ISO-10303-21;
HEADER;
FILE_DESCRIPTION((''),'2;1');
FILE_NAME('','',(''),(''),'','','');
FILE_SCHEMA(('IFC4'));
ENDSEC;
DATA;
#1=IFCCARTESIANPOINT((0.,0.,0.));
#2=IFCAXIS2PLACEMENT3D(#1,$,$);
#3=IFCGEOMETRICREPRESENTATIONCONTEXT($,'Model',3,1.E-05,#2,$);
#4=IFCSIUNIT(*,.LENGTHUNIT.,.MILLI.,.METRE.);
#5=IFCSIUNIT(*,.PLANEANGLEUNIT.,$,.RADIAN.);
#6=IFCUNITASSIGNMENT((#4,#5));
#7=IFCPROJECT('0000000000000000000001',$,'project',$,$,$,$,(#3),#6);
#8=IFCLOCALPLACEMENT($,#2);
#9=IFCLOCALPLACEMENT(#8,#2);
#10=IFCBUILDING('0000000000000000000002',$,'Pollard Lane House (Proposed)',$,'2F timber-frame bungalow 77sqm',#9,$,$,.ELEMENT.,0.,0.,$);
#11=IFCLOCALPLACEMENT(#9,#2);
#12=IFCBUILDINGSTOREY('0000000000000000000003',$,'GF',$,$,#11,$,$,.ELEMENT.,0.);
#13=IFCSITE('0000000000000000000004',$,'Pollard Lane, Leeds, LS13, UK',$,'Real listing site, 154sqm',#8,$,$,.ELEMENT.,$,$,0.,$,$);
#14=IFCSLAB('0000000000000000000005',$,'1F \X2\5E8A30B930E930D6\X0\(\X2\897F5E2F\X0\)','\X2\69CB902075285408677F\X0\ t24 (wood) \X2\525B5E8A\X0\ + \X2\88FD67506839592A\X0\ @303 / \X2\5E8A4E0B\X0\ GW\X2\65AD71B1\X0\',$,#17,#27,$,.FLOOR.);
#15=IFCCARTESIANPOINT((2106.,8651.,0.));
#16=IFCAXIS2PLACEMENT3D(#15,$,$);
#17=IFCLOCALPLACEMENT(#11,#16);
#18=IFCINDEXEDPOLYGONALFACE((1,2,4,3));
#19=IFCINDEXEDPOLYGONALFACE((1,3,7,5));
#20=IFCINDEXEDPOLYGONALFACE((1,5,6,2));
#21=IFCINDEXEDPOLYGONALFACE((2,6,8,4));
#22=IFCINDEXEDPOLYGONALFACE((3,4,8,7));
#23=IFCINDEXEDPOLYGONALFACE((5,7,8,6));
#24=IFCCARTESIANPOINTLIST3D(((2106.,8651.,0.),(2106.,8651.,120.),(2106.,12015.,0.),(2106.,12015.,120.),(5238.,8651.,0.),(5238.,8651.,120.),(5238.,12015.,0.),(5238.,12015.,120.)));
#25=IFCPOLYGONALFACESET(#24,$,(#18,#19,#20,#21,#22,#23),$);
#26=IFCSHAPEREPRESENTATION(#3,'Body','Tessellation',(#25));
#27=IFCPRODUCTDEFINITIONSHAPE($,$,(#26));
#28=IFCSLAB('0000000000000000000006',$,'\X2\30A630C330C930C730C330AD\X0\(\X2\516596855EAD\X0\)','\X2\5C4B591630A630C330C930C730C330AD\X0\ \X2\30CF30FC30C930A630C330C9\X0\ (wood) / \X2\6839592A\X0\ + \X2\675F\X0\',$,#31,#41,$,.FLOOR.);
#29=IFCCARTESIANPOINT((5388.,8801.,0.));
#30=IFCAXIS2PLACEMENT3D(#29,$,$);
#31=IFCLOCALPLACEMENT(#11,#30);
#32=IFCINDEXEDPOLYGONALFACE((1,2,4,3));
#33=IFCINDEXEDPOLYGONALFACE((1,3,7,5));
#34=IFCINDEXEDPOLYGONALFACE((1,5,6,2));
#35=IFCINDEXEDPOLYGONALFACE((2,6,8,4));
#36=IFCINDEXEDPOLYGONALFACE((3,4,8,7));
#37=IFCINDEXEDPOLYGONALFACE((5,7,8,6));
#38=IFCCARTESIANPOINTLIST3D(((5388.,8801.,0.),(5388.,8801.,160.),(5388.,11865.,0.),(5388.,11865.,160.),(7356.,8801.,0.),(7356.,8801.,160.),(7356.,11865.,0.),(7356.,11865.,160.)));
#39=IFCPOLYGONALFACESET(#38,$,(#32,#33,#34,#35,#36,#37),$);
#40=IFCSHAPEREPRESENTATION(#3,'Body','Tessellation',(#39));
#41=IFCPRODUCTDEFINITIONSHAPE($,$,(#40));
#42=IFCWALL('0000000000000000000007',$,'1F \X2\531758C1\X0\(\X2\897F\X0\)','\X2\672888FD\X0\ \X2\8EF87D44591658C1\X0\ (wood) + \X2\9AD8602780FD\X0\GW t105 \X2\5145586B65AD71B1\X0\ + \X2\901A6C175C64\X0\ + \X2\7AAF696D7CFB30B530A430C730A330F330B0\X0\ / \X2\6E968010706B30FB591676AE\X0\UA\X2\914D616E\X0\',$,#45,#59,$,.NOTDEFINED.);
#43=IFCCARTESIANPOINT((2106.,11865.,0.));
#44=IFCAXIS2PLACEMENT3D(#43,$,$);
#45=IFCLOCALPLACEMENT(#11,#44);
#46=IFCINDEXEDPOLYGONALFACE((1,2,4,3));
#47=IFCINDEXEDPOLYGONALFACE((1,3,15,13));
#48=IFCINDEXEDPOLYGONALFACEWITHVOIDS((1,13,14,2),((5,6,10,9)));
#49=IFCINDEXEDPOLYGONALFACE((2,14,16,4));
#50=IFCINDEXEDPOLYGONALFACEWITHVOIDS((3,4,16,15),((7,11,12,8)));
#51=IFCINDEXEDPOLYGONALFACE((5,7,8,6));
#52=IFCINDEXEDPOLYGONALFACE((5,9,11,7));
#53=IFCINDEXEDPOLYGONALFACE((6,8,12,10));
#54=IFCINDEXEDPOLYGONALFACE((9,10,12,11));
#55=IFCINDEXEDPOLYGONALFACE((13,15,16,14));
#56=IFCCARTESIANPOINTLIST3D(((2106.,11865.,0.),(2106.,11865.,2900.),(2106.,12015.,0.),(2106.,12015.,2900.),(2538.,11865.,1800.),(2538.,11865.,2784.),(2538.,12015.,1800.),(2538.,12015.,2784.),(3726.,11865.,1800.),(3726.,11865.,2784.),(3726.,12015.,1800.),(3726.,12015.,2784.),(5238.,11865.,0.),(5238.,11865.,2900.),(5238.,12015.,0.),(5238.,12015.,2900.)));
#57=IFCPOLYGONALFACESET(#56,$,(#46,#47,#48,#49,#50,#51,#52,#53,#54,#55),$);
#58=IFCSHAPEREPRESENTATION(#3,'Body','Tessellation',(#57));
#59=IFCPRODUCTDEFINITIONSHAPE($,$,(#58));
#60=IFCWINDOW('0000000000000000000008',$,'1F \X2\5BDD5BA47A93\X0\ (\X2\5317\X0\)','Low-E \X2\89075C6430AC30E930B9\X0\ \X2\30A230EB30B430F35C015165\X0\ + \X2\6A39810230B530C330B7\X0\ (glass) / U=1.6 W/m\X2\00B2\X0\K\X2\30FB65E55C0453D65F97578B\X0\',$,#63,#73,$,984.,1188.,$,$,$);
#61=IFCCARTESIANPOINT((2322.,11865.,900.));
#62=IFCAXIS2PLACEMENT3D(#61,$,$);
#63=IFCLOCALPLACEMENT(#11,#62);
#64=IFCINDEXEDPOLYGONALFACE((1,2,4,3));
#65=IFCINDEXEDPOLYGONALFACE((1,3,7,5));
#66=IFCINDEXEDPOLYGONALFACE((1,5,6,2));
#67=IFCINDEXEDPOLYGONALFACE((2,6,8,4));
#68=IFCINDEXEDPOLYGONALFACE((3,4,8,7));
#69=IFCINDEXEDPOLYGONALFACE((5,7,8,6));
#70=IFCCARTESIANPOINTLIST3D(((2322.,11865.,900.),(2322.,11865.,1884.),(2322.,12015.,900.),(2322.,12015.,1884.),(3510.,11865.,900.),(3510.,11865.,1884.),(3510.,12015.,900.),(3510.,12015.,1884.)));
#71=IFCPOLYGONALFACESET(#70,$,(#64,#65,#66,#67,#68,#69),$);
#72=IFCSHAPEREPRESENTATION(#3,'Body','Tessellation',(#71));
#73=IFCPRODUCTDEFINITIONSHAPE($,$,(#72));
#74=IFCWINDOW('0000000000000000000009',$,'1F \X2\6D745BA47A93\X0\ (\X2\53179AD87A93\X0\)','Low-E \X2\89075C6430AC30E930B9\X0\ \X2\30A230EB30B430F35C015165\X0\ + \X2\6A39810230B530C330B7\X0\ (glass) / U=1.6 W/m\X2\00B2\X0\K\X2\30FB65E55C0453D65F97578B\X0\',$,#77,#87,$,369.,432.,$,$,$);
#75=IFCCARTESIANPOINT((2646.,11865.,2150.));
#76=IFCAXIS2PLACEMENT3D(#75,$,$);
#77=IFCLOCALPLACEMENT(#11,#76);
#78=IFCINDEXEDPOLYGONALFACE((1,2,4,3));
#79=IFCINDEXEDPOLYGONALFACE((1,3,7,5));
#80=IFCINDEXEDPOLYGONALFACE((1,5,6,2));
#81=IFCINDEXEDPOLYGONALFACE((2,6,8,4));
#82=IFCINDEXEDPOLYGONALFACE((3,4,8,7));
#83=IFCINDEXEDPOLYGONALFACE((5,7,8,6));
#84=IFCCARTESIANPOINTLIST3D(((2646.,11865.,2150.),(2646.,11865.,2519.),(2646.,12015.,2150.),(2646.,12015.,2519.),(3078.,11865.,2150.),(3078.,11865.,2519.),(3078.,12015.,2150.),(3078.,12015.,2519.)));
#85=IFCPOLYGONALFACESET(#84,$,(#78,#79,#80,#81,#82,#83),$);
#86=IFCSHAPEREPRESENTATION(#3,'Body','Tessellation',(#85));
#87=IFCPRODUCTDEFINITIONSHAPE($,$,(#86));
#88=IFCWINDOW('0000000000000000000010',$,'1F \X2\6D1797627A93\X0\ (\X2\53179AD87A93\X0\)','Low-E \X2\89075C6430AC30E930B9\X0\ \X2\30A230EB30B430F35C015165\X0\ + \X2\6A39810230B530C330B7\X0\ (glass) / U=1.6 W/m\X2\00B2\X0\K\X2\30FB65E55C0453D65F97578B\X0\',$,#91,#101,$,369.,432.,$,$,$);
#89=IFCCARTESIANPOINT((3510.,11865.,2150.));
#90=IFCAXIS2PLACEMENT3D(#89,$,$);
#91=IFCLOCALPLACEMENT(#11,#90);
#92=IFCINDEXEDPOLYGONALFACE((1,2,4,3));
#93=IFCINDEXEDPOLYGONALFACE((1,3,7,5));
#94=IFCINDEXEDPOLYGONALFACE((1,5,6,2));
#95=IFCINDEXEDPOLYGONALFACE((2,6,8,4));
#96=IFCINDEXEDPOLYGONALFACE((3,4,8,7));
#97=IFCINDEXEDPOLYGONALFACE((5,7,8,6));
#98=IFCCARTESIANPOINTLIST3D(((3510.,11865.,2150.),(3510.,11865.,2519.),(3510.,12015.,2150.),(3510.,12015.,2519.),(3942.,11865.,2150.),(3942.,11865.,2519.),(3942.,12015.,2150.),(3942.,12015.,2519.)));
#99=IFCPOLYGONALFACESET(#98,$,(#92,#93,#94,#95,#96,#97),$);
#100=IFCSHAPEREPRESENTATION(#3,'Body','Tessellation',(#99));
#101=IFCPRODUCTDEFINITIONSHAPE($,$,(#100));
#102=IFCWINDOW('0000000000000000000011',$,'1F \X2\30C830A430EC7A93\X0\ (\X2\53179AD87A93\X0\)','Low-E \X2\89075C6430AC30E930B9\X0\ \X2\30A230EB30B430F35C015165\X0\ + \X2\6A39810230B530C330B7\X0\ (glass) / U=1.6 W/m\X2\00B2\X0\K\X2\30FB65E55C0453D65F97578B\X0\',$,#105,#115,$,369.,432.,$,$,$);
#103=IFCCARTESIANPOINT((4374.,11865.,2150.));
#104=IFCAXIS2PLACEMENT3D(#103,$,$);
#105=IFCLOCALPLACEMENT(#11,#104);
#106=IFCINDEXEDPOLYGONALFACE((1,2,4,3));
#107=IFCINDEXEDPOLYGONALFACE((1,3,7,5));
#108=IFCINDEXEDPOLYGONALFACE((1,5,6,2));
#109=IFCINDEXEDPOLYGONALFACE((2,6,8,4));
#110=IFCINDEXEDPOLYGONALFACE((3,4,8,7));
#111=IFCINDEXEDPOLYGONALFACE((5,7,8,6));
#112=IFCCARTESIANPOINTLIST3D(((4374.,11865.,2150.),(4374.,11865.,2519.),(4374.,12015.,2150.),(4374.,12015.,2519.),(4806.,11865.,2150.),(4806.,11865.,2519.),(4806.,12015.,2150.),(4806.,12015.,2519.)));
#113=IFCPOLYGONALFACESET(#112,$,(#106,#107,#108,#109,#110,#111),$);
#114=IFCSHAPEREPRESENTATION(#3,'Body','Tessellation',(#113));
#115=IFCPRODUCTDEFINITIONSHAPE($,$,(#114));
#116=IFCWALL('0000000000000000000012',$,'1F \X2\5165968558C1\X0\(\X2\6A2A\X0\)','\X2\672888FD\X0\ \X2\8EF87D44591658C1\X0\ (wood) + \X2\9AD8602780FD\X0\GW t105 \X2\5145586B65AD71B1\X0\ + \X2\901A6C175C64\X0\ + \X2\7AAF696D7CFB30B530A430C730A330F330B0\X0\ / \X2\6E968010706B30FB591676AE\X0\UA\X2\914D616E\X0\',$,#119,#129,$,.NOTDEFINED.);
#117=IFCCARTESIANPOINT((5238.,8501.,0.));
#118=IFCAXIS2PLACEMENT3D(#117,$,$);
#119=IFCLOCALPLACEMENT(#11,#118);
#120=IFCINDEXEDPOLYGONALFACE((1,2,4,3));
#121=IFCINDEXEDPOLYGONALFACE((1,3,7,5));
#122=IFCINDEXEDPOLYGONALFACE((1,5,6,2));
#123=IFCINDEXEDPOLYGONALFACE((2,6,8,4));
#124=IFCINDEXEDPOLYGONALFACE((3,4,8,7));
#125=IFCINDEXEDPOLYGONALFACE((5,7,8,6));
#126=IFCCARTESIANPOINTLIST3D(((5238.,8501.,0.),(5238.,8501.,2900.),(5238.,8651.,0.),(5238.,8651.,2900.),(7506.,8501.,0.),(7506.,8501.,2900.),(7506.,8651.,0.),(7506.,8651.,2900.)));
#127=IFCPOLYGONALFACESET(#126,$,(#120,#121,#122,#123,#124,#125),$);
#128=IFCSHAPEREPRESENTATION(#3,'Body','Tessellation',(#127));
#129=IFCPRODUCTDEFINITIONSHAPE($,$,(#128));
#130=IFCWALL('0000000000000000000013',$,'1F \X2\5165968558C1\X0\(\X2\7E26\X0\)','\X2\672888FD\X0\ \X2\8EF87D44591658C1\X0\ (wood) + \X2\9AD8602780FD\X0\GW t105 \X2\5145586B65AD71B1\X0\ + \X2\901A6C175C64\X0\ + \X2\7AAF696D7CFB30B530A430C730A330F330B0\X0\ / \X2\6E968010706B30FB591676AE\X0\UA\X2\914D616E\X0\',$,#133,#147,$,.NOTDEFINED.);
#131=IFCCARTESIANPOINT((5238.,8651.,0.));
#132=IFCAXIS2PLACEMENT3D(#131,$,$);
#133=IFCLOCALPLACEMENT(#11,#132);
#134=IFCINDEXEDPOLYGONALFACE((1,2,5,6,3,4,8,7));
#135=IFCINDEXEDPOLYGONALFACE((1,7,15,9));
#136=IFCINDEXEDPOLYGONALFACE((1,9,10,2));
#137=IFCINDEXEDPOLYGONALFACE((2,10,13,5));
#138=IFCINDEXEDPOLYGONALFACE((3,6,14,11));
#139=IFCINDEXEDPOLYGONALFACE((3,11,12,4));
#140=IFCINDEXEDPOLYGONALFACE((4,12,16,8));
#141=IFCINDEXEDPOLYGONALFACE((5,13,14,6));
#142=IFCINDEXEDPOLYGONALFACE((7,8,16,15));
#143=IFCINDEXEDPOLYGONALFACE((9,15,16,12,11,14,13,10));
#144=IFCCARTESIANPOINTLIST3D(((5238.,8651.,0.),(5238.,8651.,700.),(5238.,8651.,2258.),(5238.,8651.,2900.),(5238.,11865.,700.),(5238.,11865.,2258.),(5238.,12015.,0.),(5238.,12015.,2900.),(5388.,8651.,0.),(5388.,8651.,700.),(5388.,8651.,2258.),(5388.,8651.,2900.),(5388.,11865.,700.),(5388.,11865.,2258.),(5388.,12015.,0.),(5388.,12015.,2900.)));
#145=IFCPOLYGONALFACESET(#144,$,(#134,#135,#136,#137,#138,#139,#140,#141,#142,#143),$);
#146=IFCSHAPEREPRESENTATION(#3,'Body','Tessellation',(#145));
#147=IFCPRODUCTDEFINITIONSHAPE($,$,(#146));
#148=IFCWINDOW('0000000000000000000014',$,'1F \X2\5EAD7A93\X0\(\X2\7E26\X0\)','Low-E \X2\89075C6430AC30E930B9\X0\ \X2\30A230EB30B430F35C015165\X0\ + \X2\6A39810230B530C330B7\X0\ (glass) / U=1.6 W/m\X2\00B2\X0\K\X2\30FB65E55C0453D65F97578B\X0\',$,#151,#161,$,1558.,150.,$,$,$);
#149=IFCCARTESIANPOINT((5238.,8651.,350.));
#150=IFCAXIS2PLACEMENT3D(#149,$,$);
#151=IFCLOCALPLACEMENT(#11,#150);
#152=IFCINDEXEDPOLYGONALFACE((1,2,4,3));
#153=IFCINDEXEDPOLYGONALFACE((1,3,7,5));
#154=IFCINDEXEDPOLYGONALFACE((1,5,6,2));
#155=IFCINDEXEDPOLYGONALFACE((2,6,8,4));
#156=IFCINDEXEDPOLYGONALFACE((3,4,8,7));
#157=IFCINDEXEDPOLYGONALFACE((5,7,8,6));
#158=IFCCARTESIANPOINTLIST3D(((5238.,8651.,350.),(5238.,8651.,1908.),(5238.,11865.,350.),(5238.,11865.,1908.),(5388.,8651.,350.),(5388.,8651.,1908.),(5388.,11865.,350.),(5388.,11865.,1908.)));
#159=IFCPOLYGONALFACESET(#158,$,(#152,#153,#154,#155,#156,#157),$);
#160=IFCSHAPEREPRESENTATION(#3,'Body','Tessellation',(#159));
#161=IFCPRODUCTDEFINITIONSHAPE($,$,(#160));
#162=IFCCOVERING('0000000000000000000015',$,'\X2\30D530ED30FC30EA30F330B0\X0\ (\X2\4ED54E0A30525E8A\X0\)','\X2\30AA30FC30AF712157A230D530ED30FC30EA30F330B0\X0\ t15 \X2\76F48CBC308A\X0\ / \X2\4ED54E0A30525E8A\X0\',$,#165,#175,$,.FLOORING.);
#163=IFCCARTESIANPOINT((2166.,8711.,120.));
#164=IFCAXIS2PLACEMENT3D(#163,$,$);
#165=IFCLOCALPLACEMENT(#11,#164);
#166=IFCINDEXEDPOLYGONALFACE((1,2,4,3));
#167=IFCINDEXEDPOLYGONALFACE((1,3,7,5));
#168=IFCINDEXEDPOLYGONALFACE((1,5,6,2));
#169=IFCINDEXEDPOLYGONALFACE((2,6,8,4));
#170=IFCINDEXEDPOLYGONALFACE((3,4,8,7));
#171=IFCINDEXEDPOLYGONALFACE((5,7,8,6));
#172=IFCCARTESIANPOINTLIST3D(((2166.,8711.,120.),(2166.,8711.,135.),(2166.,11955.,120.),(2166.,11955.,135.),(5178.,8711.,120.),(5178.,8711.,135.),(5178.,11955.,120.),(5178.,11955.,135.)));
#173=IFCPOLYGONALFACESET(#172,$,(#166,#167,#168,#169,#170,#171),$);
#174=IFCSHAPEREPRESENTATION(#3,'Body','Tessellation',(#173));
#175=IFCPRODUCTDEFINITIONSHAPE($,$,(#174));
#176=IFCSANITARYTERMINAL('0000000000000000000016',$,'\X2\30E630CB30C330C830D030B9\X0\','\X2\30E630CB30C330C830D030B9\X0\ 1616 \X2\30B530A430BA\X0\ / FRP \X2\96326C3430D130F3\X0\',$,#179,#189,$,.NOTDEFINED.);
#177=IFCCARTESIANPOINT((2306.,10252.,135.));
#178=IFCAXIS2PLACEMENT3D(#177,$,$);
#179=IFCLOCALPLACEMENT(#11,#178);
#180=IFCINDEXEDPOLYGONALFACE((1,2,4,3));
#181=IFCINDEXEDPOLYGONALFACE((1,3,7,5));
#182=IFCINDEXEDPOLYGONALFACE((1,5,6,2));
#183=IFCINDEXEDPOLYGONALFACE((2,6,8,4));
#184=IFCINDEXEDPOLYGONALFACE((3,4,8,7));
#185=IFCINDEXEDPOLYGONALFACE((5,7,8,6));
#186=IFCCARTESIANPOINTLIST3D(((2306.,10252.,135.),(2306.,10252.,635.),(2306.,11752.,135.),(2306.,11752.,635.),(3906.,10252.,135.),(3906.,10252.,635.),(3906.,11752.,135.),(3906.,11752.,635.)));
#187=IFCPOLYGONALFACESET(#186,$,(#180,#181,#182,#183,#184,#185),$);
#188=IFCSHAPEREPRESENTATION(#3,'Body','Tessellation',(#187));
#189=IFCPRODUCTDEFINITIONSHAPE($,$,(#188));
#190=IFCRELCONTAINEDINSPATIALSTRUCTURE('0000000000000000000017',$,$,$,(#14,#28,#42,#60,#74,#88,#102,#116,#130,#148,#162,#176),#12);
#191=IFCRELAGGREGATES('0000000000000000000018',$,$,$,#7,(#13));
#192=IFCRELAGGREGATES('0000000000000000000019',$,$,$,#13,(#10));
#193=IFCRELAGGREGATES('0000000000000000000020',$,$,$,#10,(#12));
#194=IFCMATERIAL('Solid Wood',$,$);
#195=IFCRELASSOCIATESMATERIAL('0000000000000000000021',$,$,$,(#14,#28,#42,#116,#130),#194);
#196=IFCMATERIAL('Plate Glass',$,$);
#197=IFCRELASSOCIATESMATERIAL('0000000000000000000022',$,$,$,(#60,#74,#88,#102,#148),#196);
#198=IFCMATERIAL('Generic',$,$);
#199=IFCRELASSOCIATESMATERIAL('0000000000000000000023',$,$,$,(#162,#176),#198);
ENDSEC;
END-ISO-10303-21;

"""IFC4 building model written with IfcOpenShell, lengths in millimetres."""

from ifc_helpers import new_model, si_unit, frame, frame_2d, origin, place, context, project, spatial, rectangle, extrude, material, element, fill, save


model = new_model("IFC4")

# Units and contexts
model_context = context("Model", 3, precision=1e-05, world=origin())
ifc_project = project(units=[si_unit("LENGTHUNIT", "METRE", prefix="MILLI"), si_unit("PLANEANGLEUNIT", "RADIAN")], contexts=[model_context])

# Site, building, storey
site_placement = place(None, origin())
site = spatial("IfcSite", under=ifc_project, at=site_placement, Name="Pollard Lane, Leeds, LS13, UK", ObjectType="Real listing site, 154sqm", CompositionType="ELEMENT", RefElevation=0.0)
building_placement = place(site_placement, origin())
building = spatial("IfcBuilding", under=site, at=building_placement, Name="Pollard Lane House (Proposed)", ObjectType="2F timber-frame bungalow 77sqm", CompositionType="ELEMENT", ElevationOfRefHeight=0.0, ElevationOfTerrain=0.0)
storey_placement = place(building_placement, origin())
storey = spatial("IfcBuildingStorey", under=building, at=storey_placement, Name="GF", CompositionType="ELEMENT", Elevation=0.0)

# Slabs
ifc_material_1 = material(Name="Solid Wood")
slab_1_placement = place(storey_placement, frame((2106.0, 8651.0, 0.0)))
element("IfcSlab", 1, at=slab_1_placement, inside=storey, material=ifc_material_1, Name="1F 床スラブ(西帯)", Description="構造用合板 t24 (wood) 剛床 + 製材根太 @303 / 床下 GW断熱", PredefinedType="FLOOR", context=model_context, shape_type="SweptSolid", body=[
    extrude(rectangle(XDim=3132.0, YDim=3364.0, at=frame_2d((1566.0, 1682.0))), frame((2106.0, 8651.0, 0.0)), (0.0, 0.0, 1.0), 120.0),
])
slab_2_placement = place(storey_placement, frame((5388.0, 8801.0, 0.0)))
element("IfcSlab", 2, at=slab_2_placement, inside=storey, material=ifc_material_1, Name="ウッドデッキ(入隅庭)", Description="屋外ウッドデッキ ハードウッド (wood) / 根太 + 束", PredefinedType="FLOOR", context=model_context, shape_type="SweptSolid", body=[
    extrude(rectangle(XDim=1968.0, YDim=3064.0, at=frame_2d((984.0, 1532.0))), frame((5388.0, 8801.0, 0.0)), (0.0, 0.0, 1.0), 160.0),
])

# Wall, openings, windows
wall_1_placement = place(storey_placement, frame((2106.0, 11865.0, 0.0)))
wall_1 = element("IfcWall", 3, at=wall_1_placement, inside=storey, material=ifc_material_1, Name="1F 北壁(西)", Description="木製 軸組外壁 (wood) + 高性能GW t105 充填断熱 + 通気層 + 窯業系サイディング / 準耐火・外皮UA配慮", PredefinedType="NOTDEFINED", context=model_context, shape_type="SweptSolid", body=[
    extrude(rectangle(XDim=3132.0, YDim=150.0, at=frame_2d((1566.0, 75.0))), frame((2106.0, 11865.0, 0.0)), (0.0, 0.0, 1.0), 2900.0),
])
opening_1_placement = place(storey_placement, frame((2322.0, 11865.0, 900.0)))
opening_1 = element("IfcOpeningElement", 4, at=opening_1_placement, cuts=wall_1, PredefinedType="NOTDEFINED", context=model_context, shape_type="SweptSolid", body=[
    extrude(rectangle(XDim=1188.0, YDim=150.0, at=frame_2d((594.0, 75.0))), frame((2322.0, 11865.0, 900.0)), (0.0, 0.0, 1.0), 984.0),
])
opening_2_placement = place(storey_placement, frame((2646.0, 11865.0, 2150.0)))
opening_2 = element("IfcOpeningElement", 5, at=opening_2_placement, cuts=wall_1, PredefinedType="NOTDEFINED", context=model_context, shape_type="SweptSolid", body=[
    extrude(rectangle(XDim=432.0, YDim=150.0, at=frame_2d((216.0, 75.0))), frame((2646.0, 11865.0, 2150.0)), (0.0, 0.0, 1.0), 369.0),
])
opening_3_placement = place(storey_placement, frame((3510.0, 11865.0, 2150.0)))
opening_3 = element("IfcOpeningElement", 6, at=opening_3_placement, cuts=wall_1, PredefinedType="NOTDEFINED", context=model_context, shape_type="SweptSolid", body=[
    extrude(rectangle(XDim=432.0, YDim=150.0, at=frame_2d((216.0, 75.0))), frame((3510.0, 11865.0, 2150.0)), (0.0, 0.0, 1.0), 369.0),
])
opening_4_placement = place(storey_placement, frame((4374.0, 11865.0, 2150.0)))
opening_4 = element("IfcOpeningElement", 7, at=opening_4_placement, cuts=wall_1, PredefinedType="NOTDEFINED", context=model_context, shape_type="SweptSolid", body=[
    extrude(rectangle(XDim=432.0, YDim=150.0, at=frame_2d((216.0, 75.0))), frame((4374.0, 11865.0, 2150.0)), (0.0, 0.0, 1.0), 369.0),
])
ifc_material_2 = material(Name="Plate Glass")
window_1_placement = place(storey_placement, frame((2322.0, 11865.0, 900.0)))
window_1 = element("IfcWindow", 8, at=window_1_placement, inside=storey, material=ifc_material_2, Name="1F 寝室窓 (北)", Description="Low-E 複層ガラス アルゴン封入 + 樹脂サッシ (glass) / U=1.6 W/m²K・日射取得型", OverallHeight=984.0, OverallWidth=1188.0, context=model_context, shape_type="SweptSolid", body=[
    extrude(rectangle(XDim=1188.0, YDim=150.0, at=frame_2d((594.0, 75.0))), frame((2322.0, 11865.0, 900.0)), (0.0, 0.0, 1.0), 984.0),
])
fill(opening_1, window_1)
window_2_placement = place(storey_placement, frame((2646.0, 11865.0, 2150.0)))
window_2 = element("IfcWindow", 9, at=window_2_placement, inside=storey, material=ifc_material_2, Name="1F 浴室窓 (北高窓)", Description="Low-E 複層ガラス アルゴン封入 + 樹脂サッシ (glass) / U=1.6 W/m²K・日射取得型", OverallHeight=369.0, OverallWidth=432.0, context=model_context, shape_type="SweptSolid", body=[
    extrude(rectangle(XDim=432.0, YDim=150.0, at=frame_2d((216.0, 75.0))), frame((2646.0, 11865.0, 2150.0)), (0.0, 0.0, 1.0), 369.0),
])
fill(opening_2, window_2)
window_3_placement = place(storey_placement, frame((3510.0, 11865.0, 2150.0)))
window_3 = element("IfcWindow", 10, at=window_3_placement, inside=storey, material=ifc_material_2, Name="1F 洗面窓 (北高窓)", Description="Low-E 複層ガラス アルゴン封入 + 樹脂サッシ (glass) / U=1.6 W/m²K・日射取得型", OverallHeight=369.0, OverallWidth=432.0, context=model_context, shape_type="SweptSolid", body=[
    extrude(rectangle(XDim=432.0, YDim=150.0, at=frame_2d((216.0, 75.0))), frame((3510.0, 11865.0, 2150.0)), (0.0, 0.0, 1.0), 369.0),
])
fill(opening_3, window_3)
window_4_placement = place(storey_placement, frame((4374.0, 11865.0, 2150.0)))
window_4 = element("IfcWindow", 11, at=window_4_placement, inside=storey, material=ifc_material_2, Name="1F トイレ窓 (北高窓)", Description="Low-E 複層ガラス アルゴン封入 + 樹脂サッシ (glass) / U=1.6 W/m²K・日射取得型", OverallHeight=369.0, OverallWidth=432.0, context=model_context, shape_type="SweptSolid", body=[
    extrude(rectangle(XDim=432.0, YDim=150.0, at=frame_2d((216.0, 75.0))), frame((4374.0, 11865.0, 2150.0)), (0.0, 0.0, 1.0), 369.0),
])
fill(opening_4, window_4)

# Wall
wall_2_placement = place(storey_placement, frame((5238.0, 8501.0, 0.0)))
element("IfcWall", 12, at=wall_2_placement, inside=storey, material=ifc_material_1, Name="1F 入隅壁(横)", Description="木製 軸組外壁 (wood) + 高性能GW t105 充填断熱 + 通気層 + 窯業系サイディング / 準耐火・外皮UA配慮", PredefinedType="NOTDEFINED", context=model_context, shape_type="SweptSolid", body=[
    extrude(rectangle(XDim=2268.0, YDim=150.0, at=frame_2d((1134.0, 75.0))), frame((5238.0, 8501.0, 0.0)), (0.0, 0.0, 1.0), 2900.0),
])

# Wall, opening, window
wall_3_placement = place(storey_placement, frame((5238.0, 8651.0, 0.0)))
wall_3 = element("IfcWall", 13, at=wall_3_placement, inside=storey, material=ifc_material_1, Name="1F 入隅壁(縦)", Description="木製 軸組外壁 (wood) + 高性能GW t105 充填断熱 + 通気層 + 窯業系サイディング / 準耐火・外皮UA配慮", PredefinedType="NOTDEFINED", context=model_context, shape_type="SweptSolid", body=[
    extrude(rectangle(XDim=150.0, YDim=3364.0, at=frame_2d((75.0, 1682.0))), frame((5238.0, 8651.0, 0.0)), (0.0, 0.0, 1.0), 2900.0),
])
opening_5_placement = place(storey_placement, frame((5238.0, 8651.0, 350.0)))
opening_5 = element("IfcOpeningElement", 14, at=opening_5_placement, cuts=wall_3, PredefinedType="NOTDEFINED", context=model_context, shape_type="SweptSolid", body=[
    extrude(rectangle(XDim=150.0, YDim=3214.0, at=frame_2d((75.0, 1607.0))), frame((5238.0, 8651.0, 350.0)), (0.0, 0.0, 1.0), 1558.0),
])
window_5_placement = place(storey_placement, frame((5238.0, 8651.0, 350.0)))
window_5 = element("IfcWindow", 15, at=window_5_placement, inside=storey, material=ifc_material_2, Name="1F 庭窓(縦)", Description="Low-E 複層ガラス アルゴン封入 + 樹脂サッシ (glass) / U=1.6 W/m²K・日射取得型", OverallHeight=1558.0, OverallWidth=150.0, context=model_context, shape_type="SweptSolid", body=[
    extrude(rectangle(XDim=150.0, YDim=3214.0, at=frame_2d((75.0, 1607.0))), frame((5238.0, 8651.0, 350.0)), (0.0, 0.0, 1.0), 1558.0),
])
fill(opening_5, window_5)

# Covering
ifc_material_3 = material(Name="Generic")
covering_placement = place(storey_placement, frame((2166.0, 8711.0, 120.0)))
element("IfcCovering", 16, at=covering_placement, inside=storey, material=ifc_material_3, Name="フローリング (仕上げ床)", Description="オーク無垢フローリング t15 直貼り / 仕上げ床", PredefinedType="FLOORING", context=model_context, shape_type="SweptSolid", body=[
    extrude(rectangle(XDim=3012.0, YDim=3244.0, at=frame_2d((1506.0, 1622.0))), frame((2166.0, 8711.0, 120.0)), (0.0, 0.0, 1.0), 15.0),
])

# Sanitary terminal
sanitary_terminal_1_placement = place(storey_placement, frame((2306.0, 10252.0, 135.0)))
element("IfcSanitaryTerminal", 17, at=sanitary_terminal_1_placement, inside=storey, material=ifc_material_3, Name="ユニットバス", Description="ユニットバス 1616 サイズ / FRP 防水パン", PredefinedType="NOTDEFINED", context=model_context, shape_type="SweptSolid", body=[
    extrude(rectangle(XDim=1600.0, YDim=1500.0, at=frame_2d((800.0, 750.0))), frame((2306.0, 10252.0, 135.0)), (0.0, 0.0, 1.0), 500.0),
])

save(model, "model.ifc")
